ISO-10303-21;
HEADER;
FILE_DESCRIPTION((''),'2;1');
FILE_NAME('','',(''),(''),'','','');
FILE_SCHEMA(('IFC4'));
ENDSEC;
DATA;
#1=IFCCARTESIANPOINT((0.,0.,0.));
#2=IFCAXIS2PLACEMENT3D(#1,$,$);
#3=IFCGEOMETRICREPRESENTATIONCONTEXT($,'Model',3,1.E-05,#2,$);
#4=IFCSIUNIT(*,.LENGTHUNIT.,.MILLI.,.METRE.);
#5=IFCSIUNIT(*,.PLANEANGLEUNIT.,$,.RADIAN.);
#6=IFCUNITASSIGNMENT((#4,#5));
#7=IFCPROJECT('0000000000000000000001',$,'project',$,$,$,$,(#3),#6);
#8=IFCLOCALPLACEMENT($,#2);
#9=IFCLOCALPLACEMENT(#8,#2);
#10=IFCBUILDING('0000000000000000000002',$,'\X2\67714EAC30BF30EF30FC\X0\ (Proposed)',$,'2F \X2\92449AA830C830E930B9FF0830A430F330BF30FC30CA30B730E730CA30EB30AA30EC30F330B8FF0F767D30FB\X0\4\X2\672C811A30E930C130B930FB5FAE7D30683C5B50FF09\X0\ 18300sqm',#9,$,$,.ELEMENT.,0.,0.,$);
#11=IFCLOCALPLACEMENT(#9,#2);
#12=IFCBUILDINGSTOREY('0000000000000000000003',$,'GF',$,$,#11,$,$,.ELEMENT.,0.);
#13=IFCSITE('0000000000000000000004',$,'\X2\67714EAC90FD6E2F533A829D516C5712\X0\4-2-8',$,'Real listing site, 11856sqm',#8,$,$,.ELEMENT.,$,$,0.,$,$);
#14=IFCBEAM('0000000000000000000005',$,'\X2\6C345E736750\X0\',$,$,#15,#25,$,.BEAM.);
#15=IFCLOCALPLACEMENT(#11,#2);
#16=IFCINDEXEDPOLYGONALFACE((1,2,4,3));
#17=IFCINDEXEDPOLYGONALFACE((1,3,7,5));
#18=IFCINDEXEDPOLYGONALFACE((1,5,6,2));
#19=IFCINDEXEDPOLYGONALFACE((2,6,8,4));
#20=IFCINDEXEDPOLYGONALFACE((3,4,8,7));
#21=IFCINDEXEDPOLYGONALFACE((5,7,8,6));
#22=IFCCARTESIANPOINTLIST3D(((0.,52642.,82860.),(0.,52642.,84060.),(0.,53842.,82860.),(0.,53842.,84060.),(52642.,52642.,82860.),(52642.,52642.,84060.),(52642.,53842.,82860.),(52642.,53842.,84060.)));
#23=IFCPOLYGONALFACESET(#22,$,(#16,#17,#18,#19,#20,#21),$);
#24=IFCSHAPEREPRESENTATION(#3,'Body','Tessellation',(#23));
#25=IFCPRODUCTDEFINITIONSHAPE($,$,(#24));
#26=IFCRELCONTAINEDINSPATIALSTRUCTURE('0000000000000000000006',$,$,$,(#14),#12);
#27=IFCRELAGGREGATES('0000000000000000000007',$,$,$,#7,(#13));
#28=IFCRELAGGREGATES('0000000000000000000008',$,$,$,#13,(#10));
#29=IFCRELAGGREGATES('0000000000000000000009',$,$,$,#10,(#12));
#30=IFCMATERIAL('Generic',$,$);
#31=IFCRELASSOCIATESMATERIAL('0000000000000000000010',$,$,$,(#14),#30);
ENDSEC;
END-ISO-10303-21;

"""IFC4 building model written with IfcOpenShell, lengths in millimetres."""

from ifc_helpers import new_model, si_unit, frame, frame_2d, origin, place, context, project, spatial, rectangle, extrude, material, element, save


model = new_model("IFC4")

# Units and contexts
model_context = context("Model", 3, precision=1e-05, world=origin())
ifc_project = project(units=[si_unit("LENGTHUNIT", "METRE", prefix="MILLI"), si_unit("PLANEANGLEUNIT", "RADIAN")], contexts=[model_context])

# Site, building, storey
site_placement = place(None, origin())
site = spatial("IfcSite", under=ifc_project, at=site_placement, Name="東京都港区芝公園4-2-8", ObjectType="Real listing site, 11856sqm", CompositionType="ELEMENT", RefElevation=0.0)
building_placement = place(site_placement, origin())
building = spatial("IfcBuilding", under=site, at=building_placement, Name="東京タワー (Proposed)", ObjectType="2F 鉄骨トラス（インターナショナルオレンジ／白・4本脚ラチス・微細格子） 18300sqm", CompositionType="ELEMENT", ElevationOfRefHeight=0.0, ElevationOfTerrain=0.0)
storey_placement = place(building_placement, origin())
storey = spatial("IfcBuildingStorey", under=building, at=storey_placement, Name="GF", CompositionType="ELEMENT", Elevation=0.0)

# Shared definitions
ifc_material = material(Name="Generic")

# Beam
beam_placement = place(storey_placement, frame((0.0, 26321.0, 41430.0)))
element("IfcBeam", 1, at=beam_placement, inside=storey, material=ifc_material, Name="水平材", PredefinedType="BEAM", context=model_context, shape_type="SweptSolid", body=[
    extrude(rectangle(XDim=52642.0, YDim=1200.0, at=frame_2d((26321.0, 600.0))), frame((0.0, 26321.0, 41430.0)), (0.0, 0.0, 1.0), 1200.0),
])

save(model, "model.ifc")
